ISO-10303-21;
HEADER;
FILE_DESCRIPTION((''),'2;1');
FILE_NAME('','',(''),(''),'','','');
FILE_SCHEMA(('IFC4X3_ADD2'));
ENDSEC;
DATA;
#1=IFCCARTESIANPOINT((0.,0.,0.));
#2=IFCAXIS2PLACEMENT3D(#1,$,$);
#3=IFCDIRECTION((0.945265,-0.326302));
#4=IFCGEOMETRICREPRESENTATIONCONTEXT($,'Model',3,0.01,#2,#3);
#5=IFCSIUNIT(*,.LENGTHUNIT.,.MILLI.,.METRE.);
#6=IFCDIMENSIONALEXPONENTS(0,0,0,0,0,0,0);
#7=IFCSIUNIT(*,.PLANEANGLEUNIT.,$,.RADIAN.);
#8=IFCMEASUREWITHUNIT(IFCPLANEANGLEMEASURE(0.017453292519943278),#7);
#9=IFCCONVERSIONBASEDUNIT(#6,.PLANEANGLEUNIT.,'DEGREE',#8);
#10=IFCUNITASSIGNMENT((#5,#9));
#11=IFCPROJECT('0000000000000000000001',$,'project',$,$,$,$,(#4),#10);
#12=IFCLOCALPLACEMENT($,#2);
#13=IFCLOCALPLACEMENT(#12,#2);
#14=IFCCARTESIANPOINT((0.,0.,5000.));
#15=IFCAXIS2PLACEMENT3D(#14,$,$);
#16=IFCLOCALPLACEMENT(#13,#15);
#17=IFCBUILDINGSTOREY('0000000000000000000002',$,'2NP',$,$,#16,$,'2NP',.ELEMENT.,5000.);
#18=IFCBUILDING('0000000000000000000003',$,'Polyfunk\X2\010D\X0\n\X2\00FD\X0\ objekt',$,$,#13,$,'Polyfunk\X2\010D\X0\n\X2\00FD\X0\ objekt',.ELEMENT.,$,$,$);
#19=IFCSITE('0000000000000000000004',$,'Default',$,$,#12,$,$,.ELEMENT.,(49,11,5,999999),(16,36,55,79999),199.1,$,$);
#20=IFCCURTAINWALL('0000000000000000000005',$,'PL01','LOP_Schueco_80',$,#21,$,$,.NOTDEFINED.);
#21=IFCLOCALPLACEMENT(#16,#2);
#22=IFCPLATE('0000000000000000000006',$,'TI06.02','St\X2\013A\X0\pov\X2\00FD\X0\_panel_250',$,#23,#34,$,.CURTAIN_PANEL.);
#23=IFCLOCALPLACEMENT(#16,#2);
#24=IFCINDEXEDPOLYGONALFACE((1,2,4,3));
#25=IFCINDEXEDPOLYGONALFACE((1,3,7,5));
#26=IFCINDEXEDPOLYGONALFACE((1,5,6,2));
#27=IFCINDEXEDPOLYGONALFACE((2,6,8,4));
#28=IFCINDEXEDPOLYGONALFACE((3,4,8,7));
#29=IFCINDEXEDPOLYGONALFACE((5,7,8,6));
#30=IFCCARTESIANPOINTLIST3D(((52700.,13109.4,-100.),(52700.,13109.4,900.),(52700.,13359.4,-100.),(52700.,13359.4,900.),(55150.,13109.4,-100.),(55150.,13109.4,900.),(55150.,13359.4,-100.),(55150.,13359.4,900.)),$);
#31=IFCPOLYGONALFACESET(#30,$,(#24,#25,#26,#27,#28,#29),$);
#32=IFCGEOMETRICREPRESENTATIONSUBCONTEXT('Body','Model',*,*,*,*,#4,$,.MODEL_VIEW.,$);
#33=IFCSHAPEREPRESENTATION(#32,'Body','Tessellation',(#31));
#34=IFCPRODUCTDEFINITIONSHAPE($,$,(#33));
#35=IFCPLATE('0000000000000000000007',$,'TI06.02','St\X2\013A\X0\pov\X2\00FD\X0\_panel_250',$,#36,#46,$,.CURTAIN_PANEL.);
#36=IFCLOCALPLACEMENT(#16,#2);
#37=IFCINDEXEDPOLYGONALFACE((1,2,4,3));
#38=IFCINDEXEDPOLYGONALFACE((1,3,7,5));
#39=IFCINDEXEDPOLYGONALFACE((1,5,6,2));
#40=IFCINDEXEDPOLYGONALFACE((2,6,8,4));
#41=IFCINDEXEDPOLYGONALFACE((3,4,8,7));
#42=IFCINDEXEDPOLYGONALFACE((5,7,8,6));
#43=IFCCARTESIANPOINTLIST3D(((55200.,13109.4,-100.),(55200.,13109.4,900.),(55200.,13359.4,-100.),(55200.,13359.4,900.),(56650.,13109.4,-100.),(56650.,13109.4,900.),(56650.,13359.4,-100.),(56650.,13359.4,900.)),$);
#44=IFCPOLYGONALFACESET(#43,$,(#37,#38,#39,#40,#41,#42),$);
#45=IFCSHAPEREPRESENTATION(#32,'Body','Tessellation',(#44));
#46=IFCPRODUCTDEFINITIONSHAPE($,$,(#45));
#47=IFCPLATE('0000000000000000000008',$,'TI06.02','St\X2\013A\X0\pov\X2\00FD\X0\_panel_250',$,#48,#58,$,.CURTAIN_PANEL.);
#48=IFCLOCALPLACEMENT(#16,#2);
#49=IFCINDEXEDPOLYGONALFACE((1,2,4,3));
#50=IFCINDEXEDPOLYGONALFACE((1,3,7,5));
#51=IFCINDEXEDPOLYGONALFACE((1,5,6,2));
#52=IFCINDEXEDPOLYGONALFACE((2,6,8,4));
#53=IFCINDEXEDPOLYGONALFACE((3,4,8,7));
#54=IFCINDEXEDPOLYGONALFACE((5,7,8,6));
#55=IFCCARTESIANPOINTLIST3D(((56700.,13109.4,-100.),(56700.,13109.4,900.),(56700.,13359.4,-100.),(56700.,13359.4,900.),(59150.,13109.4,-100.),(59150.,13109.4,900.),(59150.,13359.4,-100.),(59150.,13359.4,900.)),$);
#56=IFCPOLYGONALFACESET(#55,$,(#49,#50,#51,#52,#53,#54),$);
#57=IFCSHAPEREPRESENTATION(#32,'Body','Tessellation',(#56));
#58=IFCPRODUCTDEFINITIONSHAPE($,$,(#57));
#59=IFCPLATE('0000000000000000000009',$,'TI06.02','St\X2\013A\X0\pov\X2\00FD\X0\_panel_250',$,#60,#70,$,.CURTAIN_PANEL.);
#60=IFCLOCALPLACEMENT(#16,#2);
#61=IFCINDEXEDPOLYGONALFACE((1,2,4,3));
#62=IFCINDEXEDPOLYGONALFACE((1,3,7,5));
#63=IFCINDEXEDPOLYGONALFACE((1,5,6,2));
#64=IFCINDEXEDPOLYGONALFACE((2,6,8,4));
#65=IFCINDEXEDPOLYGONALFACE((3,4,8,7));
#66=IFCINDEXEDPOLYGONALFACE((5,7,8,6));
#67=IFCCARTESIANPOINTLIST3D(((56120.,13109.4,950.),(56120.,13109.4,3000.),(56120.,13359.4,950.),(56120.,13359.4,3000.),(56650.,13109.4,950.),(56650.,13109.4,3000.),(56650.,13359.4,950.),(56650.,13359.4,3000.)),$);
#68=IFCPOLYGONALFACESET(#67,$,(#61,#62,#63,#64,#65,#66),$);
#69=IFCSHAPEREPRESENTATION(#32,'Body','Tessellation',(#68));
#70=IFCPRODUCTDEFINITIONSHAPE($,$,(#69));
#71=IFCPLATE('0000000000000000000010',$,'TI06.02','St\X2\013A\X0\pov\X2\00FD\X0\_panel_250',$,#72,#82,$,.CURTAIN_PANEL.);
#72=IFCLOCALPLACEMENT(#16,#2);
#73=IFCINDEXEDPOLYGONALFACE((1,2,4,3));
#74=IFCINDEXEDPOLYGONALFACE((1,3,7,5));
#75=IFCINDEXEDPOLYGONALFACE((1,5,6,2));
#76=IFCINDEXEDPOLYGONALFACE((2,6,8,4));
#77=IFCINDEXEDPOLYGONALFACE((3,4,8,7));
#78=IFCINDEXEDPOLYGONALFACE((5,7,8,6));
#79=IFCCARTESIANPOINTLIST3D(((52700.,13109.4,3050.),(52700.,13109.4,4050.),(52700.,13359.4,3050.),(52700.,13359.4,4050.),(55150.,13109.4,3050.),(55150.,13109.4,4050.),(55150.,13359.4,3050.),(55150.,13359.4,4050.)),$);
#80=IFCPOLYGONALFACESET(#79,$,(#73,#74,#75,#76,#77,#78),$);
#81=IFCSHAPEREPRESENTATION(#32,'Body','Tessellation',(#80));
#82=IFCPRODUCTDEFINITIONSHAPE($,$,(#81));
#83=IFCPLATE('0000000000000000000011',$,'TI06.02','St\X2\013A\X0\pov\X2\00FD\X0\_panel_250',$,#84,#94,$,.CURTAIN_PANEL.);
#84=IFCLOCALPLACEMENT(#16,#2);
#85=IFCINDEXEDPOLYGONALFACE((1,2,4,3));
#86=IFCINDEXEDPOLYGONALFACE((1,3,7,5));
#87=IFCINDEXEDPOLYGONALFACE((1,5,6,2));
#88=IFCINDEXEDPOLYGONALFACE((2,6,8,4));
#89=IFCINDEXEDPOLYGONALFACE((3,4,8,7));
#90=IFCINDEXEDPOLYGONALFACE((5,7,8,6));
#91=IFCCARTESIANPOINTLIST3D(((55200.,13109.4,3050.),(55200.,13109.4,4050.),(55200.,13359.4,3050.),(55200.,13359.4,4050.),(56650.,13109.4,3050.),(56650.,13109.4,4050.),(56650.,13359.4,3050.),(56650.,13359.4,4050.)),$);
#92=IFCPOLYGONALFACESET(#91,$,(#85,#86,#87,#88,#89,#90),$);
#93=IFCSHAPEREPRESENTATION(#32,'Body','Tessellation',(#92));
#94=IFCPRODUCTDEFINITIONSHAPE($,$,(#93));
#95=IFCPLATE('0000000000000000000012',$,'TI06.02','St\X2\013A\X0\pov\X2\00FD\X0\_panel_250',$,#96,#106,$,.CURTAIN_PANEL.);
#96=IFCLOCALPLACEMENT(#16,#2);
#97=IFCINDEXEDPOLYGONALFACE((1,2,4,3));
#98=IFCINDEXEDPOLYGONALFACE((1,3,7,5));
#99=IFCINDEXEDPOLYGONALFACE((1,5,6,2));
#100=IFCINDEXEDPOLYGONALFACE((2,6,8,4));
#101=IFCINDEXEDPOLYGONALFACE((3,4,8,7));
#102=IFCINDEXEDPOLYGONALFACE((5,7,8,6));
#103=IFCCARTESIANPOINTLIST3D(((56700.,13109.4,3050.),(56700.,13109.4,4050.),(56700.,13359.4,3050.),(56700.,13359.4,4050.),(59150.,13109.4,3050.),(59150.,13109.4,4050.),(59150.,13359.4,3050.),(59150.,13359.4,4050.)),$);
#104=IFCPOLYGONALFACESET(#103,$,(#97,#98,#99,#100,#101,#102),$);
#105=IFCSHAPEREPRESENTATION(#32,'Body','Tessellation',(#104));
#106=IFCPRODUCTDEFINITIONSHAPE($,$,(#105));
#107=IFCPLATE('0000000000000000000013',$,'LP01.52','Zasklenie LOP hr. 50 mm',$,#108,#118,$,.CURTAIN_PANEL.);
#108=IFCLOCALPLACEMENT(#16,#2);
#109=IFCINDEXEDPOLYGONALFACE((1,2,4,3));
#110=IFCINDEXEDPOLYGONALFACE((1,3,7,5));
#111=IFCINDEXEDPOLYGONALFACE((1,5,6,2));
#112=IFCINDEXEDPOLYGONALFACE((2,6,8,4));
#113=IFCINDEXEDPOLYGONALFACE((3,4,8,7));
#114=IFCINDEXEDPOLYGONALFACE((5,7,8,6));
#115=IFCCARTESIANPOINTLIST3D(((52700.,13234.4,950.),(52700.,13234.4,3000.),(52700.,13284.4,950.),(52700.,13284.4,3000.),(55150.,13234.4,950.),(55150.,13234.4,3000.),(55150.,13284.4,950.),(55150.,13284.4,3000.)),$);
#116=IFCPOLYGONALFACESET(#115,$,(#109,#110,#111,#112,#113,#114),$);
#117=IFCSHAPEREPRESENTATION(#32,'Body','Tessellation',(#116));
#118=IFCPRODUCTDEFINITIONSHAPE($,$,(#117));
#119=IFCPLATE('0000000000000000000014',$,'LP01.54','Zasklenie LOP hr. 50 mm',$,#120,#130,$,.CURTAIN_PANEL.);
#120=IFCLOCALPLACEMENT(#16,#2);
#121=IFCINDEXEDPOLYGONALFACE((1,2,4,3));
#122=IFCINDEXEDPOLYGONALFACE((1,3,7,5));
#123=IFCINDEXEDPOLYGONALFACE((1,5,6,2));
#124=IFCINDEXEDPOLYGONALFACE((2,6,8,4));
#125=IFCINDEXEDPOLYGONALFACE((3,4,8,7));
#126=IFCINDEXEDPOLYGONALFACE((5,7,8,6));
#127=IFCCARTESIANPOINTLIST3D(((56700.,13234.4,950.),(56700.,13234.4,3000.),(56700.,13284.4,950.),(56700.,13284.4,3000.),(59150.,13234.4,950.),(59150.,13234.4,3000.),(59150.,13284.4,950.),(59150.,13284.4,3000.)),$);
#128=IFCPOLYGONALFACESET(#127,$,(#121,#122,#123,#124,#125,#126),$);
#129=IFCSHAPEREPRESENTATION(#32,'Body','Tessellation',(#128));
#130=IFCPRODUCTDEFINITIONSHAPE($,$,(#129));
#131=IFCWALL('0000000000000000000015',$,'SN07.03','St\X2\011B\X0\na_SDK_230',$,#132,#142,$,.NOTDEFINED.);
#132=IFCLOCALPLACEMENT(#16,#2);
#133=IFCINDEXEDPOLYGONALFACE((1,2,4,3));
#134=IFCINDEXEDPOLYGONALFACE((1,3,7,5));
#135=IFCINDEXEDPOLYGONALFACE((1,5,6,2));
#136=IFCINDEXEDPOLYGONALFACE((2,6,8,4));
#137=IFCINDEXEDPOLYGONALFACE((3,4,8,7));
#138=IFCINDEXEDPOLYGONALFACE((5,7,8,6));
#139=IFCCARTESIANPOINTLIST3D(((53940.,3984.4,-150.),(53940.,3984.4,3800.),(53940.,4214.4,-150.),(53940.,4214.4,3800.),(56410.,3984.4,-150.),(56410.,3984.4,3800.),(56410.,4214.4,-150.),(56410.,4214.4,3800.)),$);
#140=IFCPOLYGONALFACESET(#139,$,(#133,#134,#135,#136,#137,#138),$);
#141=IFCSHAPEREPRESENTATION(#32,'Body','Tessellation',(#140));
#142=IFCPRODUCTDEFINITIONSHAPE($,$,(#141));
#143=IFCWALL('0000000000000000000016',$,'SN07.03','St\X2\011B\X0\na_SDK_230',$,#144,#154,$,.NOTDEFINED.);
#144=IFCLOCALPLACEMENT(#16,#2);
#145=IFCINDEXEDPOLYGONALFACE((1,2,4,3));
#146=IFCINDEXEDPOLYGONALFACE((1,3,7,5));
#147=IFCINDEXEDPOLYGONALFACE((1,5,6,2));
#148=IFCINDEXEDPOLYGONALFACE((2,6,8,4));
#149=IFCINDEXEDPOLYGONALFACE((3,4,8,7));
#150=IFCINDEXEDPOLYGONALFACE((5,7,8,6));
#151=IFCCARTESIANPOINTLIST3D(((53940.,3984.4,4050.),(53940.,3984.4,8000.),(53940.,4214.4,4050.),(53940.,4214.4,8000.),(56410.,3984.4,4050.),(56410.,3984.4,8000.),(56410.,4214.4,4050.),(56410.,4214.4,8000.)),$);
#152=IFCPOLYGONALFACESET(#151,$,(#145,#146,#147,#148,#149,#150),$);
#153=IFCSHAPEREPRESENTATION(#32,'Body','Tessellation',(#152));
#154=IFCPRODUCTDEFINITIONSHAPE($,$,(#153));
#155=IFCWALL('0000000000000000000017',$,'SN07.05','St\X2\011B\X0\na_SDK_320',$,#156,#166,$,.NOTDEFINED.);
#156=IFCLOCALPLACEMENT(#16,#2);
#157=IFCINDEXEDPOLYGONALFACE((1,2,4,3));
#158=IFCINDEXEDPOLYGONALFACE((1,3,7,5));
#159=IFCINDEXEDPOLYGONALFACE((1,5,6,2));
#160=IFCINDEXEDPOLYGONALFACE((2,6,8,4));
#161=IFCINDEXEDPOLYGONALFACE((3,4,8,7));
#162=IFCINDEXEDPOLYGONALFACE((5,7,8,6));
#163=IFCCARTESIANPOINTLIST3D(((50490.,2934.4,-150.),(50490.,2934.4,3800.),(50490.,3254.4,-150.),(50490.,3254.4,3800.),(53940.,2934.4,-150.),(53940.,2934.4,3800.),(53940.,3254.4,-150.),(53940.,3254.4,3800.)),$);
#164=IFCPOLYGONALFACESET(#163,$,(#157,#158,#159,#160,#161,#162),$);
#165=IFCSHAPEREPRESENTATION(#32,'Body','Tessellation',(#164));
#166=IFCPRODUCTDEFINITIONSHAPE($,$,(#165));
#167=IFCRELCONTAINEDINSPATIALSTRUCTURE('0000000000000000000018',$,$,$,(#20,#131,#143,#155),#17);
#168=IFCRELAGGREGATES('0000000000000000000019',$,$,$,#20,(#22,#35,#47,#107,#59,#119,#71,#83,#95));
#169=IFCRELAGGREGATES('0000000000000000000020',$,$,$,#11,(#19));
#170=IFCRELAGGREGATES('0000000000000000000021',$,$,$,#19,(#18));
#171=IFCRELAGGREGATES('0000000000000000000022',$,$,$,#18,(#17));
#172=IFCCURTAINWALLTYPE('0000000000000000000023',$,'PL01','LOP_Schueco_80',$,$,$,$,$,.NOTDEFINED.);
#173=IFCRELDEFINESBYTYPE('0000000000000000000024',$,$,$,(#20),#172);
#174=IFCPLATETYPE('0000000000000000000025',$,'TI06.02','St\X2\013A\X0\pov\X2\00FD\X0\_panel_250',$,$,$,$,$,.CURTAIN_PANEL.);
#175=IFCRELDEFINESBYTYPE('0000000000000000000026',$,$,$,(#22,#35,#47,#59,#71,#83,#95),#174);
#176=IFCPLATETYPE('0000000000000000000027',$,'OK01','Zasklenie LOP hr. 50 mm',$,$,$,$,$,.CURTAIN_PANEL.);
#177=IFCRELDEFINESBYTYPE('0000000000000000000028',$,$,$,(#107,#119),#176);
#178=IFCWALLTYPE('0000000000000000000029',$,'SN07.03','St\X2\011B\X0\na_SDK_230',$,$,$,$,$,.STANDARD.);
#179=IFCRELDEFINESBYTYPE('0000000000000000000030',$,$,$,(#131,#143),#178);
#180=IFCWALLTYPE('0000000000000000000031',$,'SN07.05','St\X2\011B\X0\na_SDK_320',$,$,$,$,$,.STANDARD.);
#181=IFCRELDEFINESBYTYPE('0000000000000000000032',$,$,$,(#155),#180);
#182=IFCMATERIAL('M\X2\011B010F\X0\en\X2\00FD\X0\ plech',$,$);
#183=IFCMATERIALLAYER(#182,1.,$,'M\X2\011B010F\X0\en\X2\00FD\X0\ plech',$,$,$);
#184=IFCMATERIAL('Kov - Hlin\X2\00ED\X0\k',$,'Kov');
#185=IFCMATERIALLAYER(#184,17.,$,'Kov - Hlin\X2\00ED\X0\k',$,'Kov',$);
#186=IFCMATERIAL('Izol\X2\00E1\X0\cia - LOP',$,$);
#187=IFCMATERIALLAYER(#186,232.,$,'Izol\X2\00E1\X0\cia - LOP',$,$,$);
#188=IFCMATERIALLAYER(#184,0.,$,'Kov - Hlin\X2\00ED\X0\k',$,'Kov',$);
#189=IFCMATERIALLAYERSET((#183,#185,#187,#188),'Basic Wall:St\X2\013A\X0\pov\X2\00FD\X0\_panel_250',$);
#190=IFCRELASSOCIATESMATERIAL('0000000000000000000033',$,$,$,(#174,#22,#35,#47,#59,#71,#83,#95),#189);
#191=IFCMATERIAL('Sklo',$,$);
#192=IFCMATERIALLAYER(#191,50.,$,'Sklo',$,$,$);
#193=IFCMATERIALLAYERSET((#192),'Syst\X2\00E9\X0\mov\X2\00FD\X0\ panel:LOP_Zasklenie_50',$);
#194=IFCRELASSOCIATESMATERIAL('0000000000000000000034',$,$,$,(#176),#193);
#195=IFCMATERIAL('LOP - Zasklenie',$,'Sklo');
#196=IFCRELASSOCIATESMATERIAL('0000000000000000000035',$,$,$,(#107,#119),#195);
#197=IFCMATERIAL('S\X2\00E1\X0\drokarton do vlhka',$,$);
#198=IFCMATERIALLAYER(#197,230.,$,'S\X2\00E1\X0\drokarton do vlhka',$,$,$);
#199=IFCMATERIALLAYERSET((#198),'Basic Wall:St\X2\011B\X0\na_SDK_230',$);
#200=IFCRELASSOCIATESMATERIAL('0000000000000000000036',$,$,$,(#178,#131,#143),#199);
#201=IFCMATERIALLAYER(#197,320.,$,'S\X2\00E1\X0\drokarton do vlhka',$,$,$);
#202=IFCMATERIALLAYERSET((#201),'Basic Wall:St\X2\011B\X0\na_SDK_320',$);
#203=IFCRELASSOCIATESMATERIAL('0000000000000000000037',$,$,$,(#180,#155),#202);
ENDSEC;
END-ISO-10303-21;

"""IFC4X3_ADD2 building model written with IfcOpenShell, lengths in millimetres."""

from ifc_helpers import new_model, entity, si_unit, converted_unit, direction, frame, frame_2d, origin, origin_2d_with_axis, place, context, subcontext, project, spatial, polyline, rectangle, extrude, clip, bounded_halfspace, source, transform, mapped, material, layer, layer_set, layer_usage, type_object, type_shapes, element, aggregate, save


model = new_model("IFC4X3_ADD2")

# Units and contexts
model_context = context("Model", 3, precision=0.01, world=origin(), true_north=direction((0.945265, -0.326302)))
body_context = subcontext(model_context, "Body", "Model", "MODEL_VIEW")
ifc_project = project(units=[si_unit("LENGTHUNIT", "METRE", prefix="MILLI"), converted_unit("PLANEANGLEUNIT", "DEGREE", entity("IfcPlaneAngleMeasure", 0.017453292519943278), si_unit("PLANEANGLEUNIT", "RADIAN"), dimensions=[0, 0, 0, 0, 0, 0, 0])], contexts=[model_context])

# Site, building, storey
site_placement = place(None, origin())
site = spatial("IfcSite", under=ifc_project, at=site_placement, Name="Default", CompositionType="ELEMENT", RefLatitude=(49, 11, 5, 999999), RefLongitude=(16, 36, 55, 79999), RefElevation=199.1)
building_placement = place(site_placement, origin())
building = spatial("IfcBuilding", under=site, at=building_placement, Name="Polyfunkčný objekt", LongName="Polyfunkčný objekt", CompositionType="ELEMENT")
storey_placement = place(building_placement, frame((0.0, 0.0, 5000.0)))
storey = spatial("IfcBuildingStorey", under=building, at=storey_placement, Name="2NP", LongName="2NP", CompositionType="ELEMENT", Elevation=5000.0)

# Curtain wall, plates
curtain_wall_type = type_object("IfcCurtainWallType", Name="PL01", Description="LOP_Schueco_80", PredefinedType="NOTDEFINED")
curtain_wall_placement = place(storey_placement, frame((0.0, 0.0, -5000.0)))
curtain_wall = element("IfcCurtainWall", 1, at=curtain_wall_placement, inside=storey, type_object=curtain_wall_type, Name="PL01", Description="LOP_Schueco_80", PredefinedType="NOTDEFINED")
ifc_material_1 = material(Name="Měďený plech")
ifc_layer_1 = layer(ifc_material_1, 1.0, Name="Měďený plech")
ifc_material_2 = material(Name="Kov - Hliník", Category="Kov")
ifc_layer_2 = layer(ifc_material_2, 17.0, Name="Kov - Hliník", Category="Kov")
ifc_material_3 = material(Name="Izolácia - LOP")
ifc_layer_3 = layer(ifc_material_3, 232.0, Name="Izolácia - LOP")
ifc_layer_4 = layer(ifc_material_2, 0.0, Name="Kov - Hliník", Category="Kov")
ifc_layer_set_1 = layer_set([ifc_layer_1, ifc_layer_2, ifc_layer_3, ifc_layer_4], Name="Basic Wall:Stĺpový_panel_250")
ifc_layer_usage_1 = layer_usage(ifc_layer_set_1, "AXIS2", "NEGATIVE", 125.0)
plate_type_1 = type_object("IfcPlateType", Name="TI06.02", Description="Stĺpový_panel_250", PredefinedType="CURTAIN_PANEL", material=ifc_layer_set_1)
plate_1_placement = place(storey_placement, frame((52700.0, 13234.4, -100.0)))
plate_1 = element("IfcPlate", 2, at=plate_1_placement, type_object=plate_type_1, material=ifc_layer_usage_1, Name="TI06.02", Description="Stĺpový_panel_250", PredefinedType="CURTAIN_PANEL", context=body_context, shape_type="SweptSolid", body=[
    extrude(rectangle(XDim=250.0, YDim=2450.0, at=origin_2d_with_axis()), frame((1225.0, 0.0, 0.0), z_axis=(0.0, 0.0, 1.0), x_axis=(0.0, 1.0, 0.0)), (0.0, 0.0, 1.0), 1000.0),
])
ifc_layer_usage_2 = layer_usage(ifc_layer_set_1, "AXIS2", "NEGATIVE", 125.0)
plate_2_placement = place(storey_placement, frame((55200.0, 13234.4, -100.0)))
plate_2 = element("IfcPlate", 3, at=plate_2_placement, type_object=plate_type_1, material=ifc_layer_usage_2, Name="TI06.02", Description="Stĺpový_panel_250", PredefinedType="CURTAIN_PANEL", context=body_context, shape_type="SweptSolid", body=[
    extrude(rectangle(XDim=250.0, YDim=1450.0, at=origin_2d_with_axis()), frame((725.0, 0.0, 0.0), z_axis=(0.0, 0.0, 1.0), x_axis=(0.0, 1.0, 0.0)), (0.0, 0.0, 1.0), 1000.0),
])
ifc_layer_usage_3 = layer_usage(ifc_layer_set_1, "AXIS2", "NEGATIVE", 125.0)
plate_3_placement = place(storey_placement, frame((56700.0, 13234.4, -100.0)))
plate_3 = element("IfcPlate", 4, at=plate_3_placement, type_object=plate_type_1, material=ifc_layer_usage_3, Name="TI06.02", Description="Stĺpový_panel_250", PredefinedType="CURTAIN_PANEL", context=body_context, shape_type="SweptSolid", body=[
    extrude(rectangle(XDim=250.0, YDim=2450.0, at=frame_2d((0.0, 0.0), x_axis=(1.0, 0.0))), frame((1225.0, 0.0, 0.0), z_axis=(0.0, 0.0, 1.0), x_axis=(0.0, 1.0, 0.0)), (0.0, 0.0, 1.0), 1000.0),
])
ifc_layer_usage_4 = layer_usage(ifc_layer_set_1, "AXIS2", "NEGATIVE", 125.0)
plate_4_placement = place(storey_placement, frame((56120.0, 13234.4, 950.0)))
plate_4 = element("IfcPlate", 5, at=plate_4_placement, type_object=plate_type_1, material=ifc_layer_usage_4, Name="TI06.02", Description="Stĺpový_panel_250", PredefinedType="CURTAIN_PANEL", context=body_context, shape_type="SweptSolid", body=[
    extrude(rectangle(XDim=250.0, YDim=530.0, at=frame_2d((0.0, 0.0), x_axis=(1.0, 0.0))), frame((265.0, 0.0, 0.0), z_axis=(0.0, 0.0, 1.0), x_axis=(0.0, 1.0, 0.0)), (0.0, 0.0, 1.0), 2050.0),
])
ifc_layer_usage_5 = layer_usage(ifc_layer_set_1, "AXIS2", "NEGATIVE", 125.0)
plate_5_placement = place(storey_placement, frame((52700.0, 13234.4, 3050.0)))
plate_5 = element("IfcPlate", 6, at=plate_5_placement, type_object=plate_type_1, material=ifc_layer_usage_5, Name="TI06.02", Description="Stĺpový_panel_250", PredefinedType="CURTAIN_PANEL", context=body_context, shape_type="SweptSolid", body=[
    extrude(rectangle(XDim=250.0, YDim=2450.0, at=origin_2d_with_axis()), frame((1225.0, 0.0, 0.0), z_axis=(0.0, 0.0, 1.0), x_axis=(0.0, 1.0, 0.0)), (0.0, 0.0, 1.0), 1000.0),
])
ifc_layer_usage_6 = layer_usage(ifc_layer_set_1, "AXIS2", "NEGATIVE", 125.0)
plate_6_placement = place(storey_placement, frame((55200.0, 13234.4, 3050.0)))
plate_6 = element("IfcPlate", 7, at=plate_6_placement, type_object=plate_type_1, material=ifc_layer_usage_6, Name="TI06.02", Description="Stĺpový_panel_250", PredefinedType="CURTAIN_PANEL", context=body_context, shape_type="SweptSolid", body=[
    extrude(rectangle(XDim=250.0, YDim=1450.0, at=origin_2d_with_axis()), frame((725.0, 0.0, 0.0), z_axis=(0.0, 0.0, 1.0), x_axis=(0.0, 1.0, 0.0)), (0.0, 0.0, 1.0), 1000.0),
])
ifc_layer_usage_7 = layer_usage(ifc_layer_set_1, "AXIS2", "NEGATIVE", 125.0)
plate_7_placement = place(storey_placement, frame((56700.0, 13234.4, 3050.0)))
plate_7 = element("IfcPlate", 8, at=plate_7_placement, type_object=plate_type_1, material=ifc_layer_usage_7, Name="TI06.02", Description="Stĺpový_panel_250", PredefinedType="CURTAIN_PANEL", context=body_context, shape_type="SweptSolid", body=[
    extrude(rectangle(XDim=250.0, YDim=2450.0, at=frame_2d((0.0, 0.0), x_axis=(1.0, 0.0))), frame((1225.0, 0.0, 0.0), z_axis=(0.0, 0.0, 1.0), x_axis=(0.0, 1.0, 0.0)), (0.0, 0.0, 1.0), 1000.0),
])
ifc_material_4 = material(Name="LOP - Zasklenie", Category="Sklo")
ifc_material_5 = material(Name="Sklo")
ifc_layer_5 = layer(ifc_material_5, 50.0, Name="Sklo")
ifc_layer_set_2 = layer_set([ifc_layer_5], Name="Systémový panel:LOP_Zasklenie_50")
plate_type_2 = type_object("IfcPlateType", Name="OK01", Description="Zasklenie LOP hr. 50 mm", PredefinedType="CURTAIN_PANEL", material=ifc_layer_set_2)
shared_shape_1 = source(origin(), body_context, "Body", "SweptSolid", [
    extrude(rectangle(XDim=50.0, YDim=2450.0, at=origin_2d_with_axis()), frame((0.0, 25.0, 0.0), z_axis=(0.0, 0.0, 1.0), x_axis=(0.0, 1.0, 0.0)), (0.0, 0.0, 1.0), 2050.0),
])
type_shapes(plate_type_2, [shared_shape_1])
plate_8_placement = place(curtain_wall_placement, frame((53925.0, 13234.4, 5950.0)))
plate_8 = element("IfcPlate", 9, at=plate_8_placement, type_object=plate_type_2, material=ifc_material_4, Name="LP01.52", Description="Zasklenie LOP hr. 50 mm", PredefinedType="CURTAIN_PANEL", context=body_context, shape_type="MappedRepresentation", body=[
    mapped(shared_shape_1, transform((0.0, 0.0, 0.0), scale=1.0)),
])
plate_9_placement = place(curtain_wall_placement, frame((57925.0, 13234.4, 5950.0)))
plate_9 = element("IfcPlate", 10, at=plate_9_placement, type_object=plate_type_2, material=ifc_material_4, Name="LP01.54", Description="Zasklenie LOP hr. 50 mm", PredefinedType="CURTAIN_PANEL", context=body_context, shape_type="MappedRepresentation", body=[
    mapped(shared_shape_1, transform((0.0, 0.0, 0.0), scale=1.0)),
])

# Walls
ifc_material_6 = material(Name="Sádrokarton do vlhka")
ifc_layer_6 = layer(ifc_material_6, 230.0, Name="Sádrokarton do vlhka")
ifc_layer_set_3 = layer_set([ifc_layer_6], Name="Basic Wall:Stěna_SDK_230")
wall_type_1 = type_object("IfcWallType", Name="SN07.03", Description="Stěna_SDK_230", PredefinedType="STANDARD", material=ifc_layer_set_3)
wall_1_placement = place(storey_placement, frame((56410.0, 4099.4, -150.0), z_axis=(0.0, 0.0, 1.0), x_axis=(-1.0, 0.0, 0.0)))
element("IfcWall", 11, at=wall_1_placement, inside=storey, type_object=wall_type_1, material=ifc_layer_set_3, Name="SN07.03", Description="Stěna_SDK_230", PredefinedType="NOTDEFINED", context=body_context, shape_type="Clipping", body=[
    clip(clip(extrude(rectangle(XDim=2470.0, YDim=230.0, at=frame_2d((1235.0, 0.0), x_axis=(-1.0, 0.0))), origin(), (0.0, 0.0, 1.0), 3950.0), bounded_halfspace(frame((2470.0, -115.0, 0.0)), True, frame((2470.0, -115.0, 0.0)), polyline([(0.0, 0.0), (0.0, 60.0), (0.0, 230.0), (-320.0, 230.0), (-2470.0, 230.0), (-2470.0, 0.0), (-150.0, 0.0), (0.0, 0.0)]))), bounded_halfspace(frame((0.0, -115.0, 3950.0), z_axis=(0.0, 0.0, -1.0), x_axis=(-1.0, 0.0, 0.0)), True, frame((0.0, -115.0, 3950.0)), polyline([(0.0, 0.0), (2320.0, 0.0), (2470.0, 0.0), (2470.0, 60.0), (2470.0, 230.0), (2150.0, 230.0), (0.0, 230.0), (0.0, 0.0)]))),
])
wall_2_placement = place(storey_placement, frame((56410.0, 4099.4, 4050.0), z_axis=(0.0, 0.0, 1.0), x_axis=(-1.0, 0.0, 0.0)))
element("IfcWall", 12, at=wall_2_placement, inside=storey, type_object=wall_type_1, material=ifc_layer_set_3, Name="SN07.03", Description="Stěna_SDK_230", PredefinedType="NOTDEFINED", context=body_context, shape_type="Clipping", body=[
    clip(clip(extrude(rectangle(XDim=2470.0, YDim=230.0, at=frame_2d((1235.0, 0.0), x_axis=(-1.0, 0.0))), origin(), (0.0, 0.0, 1.0), 3950.0), bounded_halfspace(frame((2470.0, -115.0, 0.0)), True, frame((2470.0, -115.0, 0.0)), polyline([(0.0, 0.0), (0.0, 60.0), (0.0, 230.0), (-320.0, 230.0), (-2470.0, 230.0), (-2470.0, 0.0), (-150.0, 0.0), (0.0, 0.0)]))), bounded_halfspace(frame((0.0, -115.0, 3950.0), z_axis=(0.0, 0.0, -1.0), x_axis=(-1.0, 0.0, 0.0)), True, frame((0.0, -115.0, 3950.0)), polyline([(0.0, 0.0), (2320.0, 0.0), (2470.0, 0.0), (2470.0, 60.0), (2470.0, 230.0), (2150.0, 230.0), (0.0, 230.0), (0.0, 0.0)]))),
])
ifc_layer_7 = layer(ifc_material_6, 320.0, Name="Sádrokarton do vlhka")
ifc_layer_set_4 = layer_set([ifc_layer_7], Name="Basic Wall:Stěna_SDK_320")
wall_type_2 = type_object("IfcWallType", Name="SN07.05", Description="Stěna_SDK_320", PredefinedType="STANDARD", material=ifc_layer_set_4)
wall_3_placement = place(storey_placement, frame((53940.0, 3094.4, -150.0), z_axis=(0.0, 0.0, 1.0), x_axis=(-1.0, 0.0, 0.0)))
element("IfcWall", 13, at=wall_3_placement, inside=storey, type_object=wall_type_2, material=ifc_layer_set_4, Name="SN07.05", Description="Stěna_SDK_320", PredefinedType="NOTDEFINED", context=body_context, shape_type="Clipping", body=[
    clip(clip(extrude(rectangle(XDim=3450.0, YDim=320.0, at=frame_2d((1725.0, 0.0), x_axis=(-1.0, 0.0))), origin(), (0.0, 0.0, 1.0), 3950.0), bounded_halfspace(frame((3450.0, -160.0, 0.0)), True, frame((3450.0, -160.0, 0.0)), polyline([(0.0, 0.0), (0.0, 320.0), (-1650.0, 320.0), (-1800.0, 320.0), (-3450.0, 320.0), (-3450.0, 0.0), (-1800.0, 0.0), (-1650.0, 0.0), (0.0, 0.0)]))), bounded_halfspace(frame((0.0, -160.0, 3950.0), z_axis=(0.0, 0.0, -1.0), x_axis=(-1.0, 0.0, 0.0)), True, frame((0.0, -160.0, 3950.0)), polyline([(0.0, 0.0), (1650.0, 0.0), (1800.0, 0.0), (3450.0, 0.0), (3450.0, 320.0), (1800.0, 320.0), (1650.0, 320.0), (0.0, 320.0), (0.0, 0.0)]))),
])

aggregate(curtain_wall, [plate_1, plate_2, plate_3, plate_8, plate_4, plate_9, plate_5, plate_6, plate_7])

save(model, "model.ifc")
